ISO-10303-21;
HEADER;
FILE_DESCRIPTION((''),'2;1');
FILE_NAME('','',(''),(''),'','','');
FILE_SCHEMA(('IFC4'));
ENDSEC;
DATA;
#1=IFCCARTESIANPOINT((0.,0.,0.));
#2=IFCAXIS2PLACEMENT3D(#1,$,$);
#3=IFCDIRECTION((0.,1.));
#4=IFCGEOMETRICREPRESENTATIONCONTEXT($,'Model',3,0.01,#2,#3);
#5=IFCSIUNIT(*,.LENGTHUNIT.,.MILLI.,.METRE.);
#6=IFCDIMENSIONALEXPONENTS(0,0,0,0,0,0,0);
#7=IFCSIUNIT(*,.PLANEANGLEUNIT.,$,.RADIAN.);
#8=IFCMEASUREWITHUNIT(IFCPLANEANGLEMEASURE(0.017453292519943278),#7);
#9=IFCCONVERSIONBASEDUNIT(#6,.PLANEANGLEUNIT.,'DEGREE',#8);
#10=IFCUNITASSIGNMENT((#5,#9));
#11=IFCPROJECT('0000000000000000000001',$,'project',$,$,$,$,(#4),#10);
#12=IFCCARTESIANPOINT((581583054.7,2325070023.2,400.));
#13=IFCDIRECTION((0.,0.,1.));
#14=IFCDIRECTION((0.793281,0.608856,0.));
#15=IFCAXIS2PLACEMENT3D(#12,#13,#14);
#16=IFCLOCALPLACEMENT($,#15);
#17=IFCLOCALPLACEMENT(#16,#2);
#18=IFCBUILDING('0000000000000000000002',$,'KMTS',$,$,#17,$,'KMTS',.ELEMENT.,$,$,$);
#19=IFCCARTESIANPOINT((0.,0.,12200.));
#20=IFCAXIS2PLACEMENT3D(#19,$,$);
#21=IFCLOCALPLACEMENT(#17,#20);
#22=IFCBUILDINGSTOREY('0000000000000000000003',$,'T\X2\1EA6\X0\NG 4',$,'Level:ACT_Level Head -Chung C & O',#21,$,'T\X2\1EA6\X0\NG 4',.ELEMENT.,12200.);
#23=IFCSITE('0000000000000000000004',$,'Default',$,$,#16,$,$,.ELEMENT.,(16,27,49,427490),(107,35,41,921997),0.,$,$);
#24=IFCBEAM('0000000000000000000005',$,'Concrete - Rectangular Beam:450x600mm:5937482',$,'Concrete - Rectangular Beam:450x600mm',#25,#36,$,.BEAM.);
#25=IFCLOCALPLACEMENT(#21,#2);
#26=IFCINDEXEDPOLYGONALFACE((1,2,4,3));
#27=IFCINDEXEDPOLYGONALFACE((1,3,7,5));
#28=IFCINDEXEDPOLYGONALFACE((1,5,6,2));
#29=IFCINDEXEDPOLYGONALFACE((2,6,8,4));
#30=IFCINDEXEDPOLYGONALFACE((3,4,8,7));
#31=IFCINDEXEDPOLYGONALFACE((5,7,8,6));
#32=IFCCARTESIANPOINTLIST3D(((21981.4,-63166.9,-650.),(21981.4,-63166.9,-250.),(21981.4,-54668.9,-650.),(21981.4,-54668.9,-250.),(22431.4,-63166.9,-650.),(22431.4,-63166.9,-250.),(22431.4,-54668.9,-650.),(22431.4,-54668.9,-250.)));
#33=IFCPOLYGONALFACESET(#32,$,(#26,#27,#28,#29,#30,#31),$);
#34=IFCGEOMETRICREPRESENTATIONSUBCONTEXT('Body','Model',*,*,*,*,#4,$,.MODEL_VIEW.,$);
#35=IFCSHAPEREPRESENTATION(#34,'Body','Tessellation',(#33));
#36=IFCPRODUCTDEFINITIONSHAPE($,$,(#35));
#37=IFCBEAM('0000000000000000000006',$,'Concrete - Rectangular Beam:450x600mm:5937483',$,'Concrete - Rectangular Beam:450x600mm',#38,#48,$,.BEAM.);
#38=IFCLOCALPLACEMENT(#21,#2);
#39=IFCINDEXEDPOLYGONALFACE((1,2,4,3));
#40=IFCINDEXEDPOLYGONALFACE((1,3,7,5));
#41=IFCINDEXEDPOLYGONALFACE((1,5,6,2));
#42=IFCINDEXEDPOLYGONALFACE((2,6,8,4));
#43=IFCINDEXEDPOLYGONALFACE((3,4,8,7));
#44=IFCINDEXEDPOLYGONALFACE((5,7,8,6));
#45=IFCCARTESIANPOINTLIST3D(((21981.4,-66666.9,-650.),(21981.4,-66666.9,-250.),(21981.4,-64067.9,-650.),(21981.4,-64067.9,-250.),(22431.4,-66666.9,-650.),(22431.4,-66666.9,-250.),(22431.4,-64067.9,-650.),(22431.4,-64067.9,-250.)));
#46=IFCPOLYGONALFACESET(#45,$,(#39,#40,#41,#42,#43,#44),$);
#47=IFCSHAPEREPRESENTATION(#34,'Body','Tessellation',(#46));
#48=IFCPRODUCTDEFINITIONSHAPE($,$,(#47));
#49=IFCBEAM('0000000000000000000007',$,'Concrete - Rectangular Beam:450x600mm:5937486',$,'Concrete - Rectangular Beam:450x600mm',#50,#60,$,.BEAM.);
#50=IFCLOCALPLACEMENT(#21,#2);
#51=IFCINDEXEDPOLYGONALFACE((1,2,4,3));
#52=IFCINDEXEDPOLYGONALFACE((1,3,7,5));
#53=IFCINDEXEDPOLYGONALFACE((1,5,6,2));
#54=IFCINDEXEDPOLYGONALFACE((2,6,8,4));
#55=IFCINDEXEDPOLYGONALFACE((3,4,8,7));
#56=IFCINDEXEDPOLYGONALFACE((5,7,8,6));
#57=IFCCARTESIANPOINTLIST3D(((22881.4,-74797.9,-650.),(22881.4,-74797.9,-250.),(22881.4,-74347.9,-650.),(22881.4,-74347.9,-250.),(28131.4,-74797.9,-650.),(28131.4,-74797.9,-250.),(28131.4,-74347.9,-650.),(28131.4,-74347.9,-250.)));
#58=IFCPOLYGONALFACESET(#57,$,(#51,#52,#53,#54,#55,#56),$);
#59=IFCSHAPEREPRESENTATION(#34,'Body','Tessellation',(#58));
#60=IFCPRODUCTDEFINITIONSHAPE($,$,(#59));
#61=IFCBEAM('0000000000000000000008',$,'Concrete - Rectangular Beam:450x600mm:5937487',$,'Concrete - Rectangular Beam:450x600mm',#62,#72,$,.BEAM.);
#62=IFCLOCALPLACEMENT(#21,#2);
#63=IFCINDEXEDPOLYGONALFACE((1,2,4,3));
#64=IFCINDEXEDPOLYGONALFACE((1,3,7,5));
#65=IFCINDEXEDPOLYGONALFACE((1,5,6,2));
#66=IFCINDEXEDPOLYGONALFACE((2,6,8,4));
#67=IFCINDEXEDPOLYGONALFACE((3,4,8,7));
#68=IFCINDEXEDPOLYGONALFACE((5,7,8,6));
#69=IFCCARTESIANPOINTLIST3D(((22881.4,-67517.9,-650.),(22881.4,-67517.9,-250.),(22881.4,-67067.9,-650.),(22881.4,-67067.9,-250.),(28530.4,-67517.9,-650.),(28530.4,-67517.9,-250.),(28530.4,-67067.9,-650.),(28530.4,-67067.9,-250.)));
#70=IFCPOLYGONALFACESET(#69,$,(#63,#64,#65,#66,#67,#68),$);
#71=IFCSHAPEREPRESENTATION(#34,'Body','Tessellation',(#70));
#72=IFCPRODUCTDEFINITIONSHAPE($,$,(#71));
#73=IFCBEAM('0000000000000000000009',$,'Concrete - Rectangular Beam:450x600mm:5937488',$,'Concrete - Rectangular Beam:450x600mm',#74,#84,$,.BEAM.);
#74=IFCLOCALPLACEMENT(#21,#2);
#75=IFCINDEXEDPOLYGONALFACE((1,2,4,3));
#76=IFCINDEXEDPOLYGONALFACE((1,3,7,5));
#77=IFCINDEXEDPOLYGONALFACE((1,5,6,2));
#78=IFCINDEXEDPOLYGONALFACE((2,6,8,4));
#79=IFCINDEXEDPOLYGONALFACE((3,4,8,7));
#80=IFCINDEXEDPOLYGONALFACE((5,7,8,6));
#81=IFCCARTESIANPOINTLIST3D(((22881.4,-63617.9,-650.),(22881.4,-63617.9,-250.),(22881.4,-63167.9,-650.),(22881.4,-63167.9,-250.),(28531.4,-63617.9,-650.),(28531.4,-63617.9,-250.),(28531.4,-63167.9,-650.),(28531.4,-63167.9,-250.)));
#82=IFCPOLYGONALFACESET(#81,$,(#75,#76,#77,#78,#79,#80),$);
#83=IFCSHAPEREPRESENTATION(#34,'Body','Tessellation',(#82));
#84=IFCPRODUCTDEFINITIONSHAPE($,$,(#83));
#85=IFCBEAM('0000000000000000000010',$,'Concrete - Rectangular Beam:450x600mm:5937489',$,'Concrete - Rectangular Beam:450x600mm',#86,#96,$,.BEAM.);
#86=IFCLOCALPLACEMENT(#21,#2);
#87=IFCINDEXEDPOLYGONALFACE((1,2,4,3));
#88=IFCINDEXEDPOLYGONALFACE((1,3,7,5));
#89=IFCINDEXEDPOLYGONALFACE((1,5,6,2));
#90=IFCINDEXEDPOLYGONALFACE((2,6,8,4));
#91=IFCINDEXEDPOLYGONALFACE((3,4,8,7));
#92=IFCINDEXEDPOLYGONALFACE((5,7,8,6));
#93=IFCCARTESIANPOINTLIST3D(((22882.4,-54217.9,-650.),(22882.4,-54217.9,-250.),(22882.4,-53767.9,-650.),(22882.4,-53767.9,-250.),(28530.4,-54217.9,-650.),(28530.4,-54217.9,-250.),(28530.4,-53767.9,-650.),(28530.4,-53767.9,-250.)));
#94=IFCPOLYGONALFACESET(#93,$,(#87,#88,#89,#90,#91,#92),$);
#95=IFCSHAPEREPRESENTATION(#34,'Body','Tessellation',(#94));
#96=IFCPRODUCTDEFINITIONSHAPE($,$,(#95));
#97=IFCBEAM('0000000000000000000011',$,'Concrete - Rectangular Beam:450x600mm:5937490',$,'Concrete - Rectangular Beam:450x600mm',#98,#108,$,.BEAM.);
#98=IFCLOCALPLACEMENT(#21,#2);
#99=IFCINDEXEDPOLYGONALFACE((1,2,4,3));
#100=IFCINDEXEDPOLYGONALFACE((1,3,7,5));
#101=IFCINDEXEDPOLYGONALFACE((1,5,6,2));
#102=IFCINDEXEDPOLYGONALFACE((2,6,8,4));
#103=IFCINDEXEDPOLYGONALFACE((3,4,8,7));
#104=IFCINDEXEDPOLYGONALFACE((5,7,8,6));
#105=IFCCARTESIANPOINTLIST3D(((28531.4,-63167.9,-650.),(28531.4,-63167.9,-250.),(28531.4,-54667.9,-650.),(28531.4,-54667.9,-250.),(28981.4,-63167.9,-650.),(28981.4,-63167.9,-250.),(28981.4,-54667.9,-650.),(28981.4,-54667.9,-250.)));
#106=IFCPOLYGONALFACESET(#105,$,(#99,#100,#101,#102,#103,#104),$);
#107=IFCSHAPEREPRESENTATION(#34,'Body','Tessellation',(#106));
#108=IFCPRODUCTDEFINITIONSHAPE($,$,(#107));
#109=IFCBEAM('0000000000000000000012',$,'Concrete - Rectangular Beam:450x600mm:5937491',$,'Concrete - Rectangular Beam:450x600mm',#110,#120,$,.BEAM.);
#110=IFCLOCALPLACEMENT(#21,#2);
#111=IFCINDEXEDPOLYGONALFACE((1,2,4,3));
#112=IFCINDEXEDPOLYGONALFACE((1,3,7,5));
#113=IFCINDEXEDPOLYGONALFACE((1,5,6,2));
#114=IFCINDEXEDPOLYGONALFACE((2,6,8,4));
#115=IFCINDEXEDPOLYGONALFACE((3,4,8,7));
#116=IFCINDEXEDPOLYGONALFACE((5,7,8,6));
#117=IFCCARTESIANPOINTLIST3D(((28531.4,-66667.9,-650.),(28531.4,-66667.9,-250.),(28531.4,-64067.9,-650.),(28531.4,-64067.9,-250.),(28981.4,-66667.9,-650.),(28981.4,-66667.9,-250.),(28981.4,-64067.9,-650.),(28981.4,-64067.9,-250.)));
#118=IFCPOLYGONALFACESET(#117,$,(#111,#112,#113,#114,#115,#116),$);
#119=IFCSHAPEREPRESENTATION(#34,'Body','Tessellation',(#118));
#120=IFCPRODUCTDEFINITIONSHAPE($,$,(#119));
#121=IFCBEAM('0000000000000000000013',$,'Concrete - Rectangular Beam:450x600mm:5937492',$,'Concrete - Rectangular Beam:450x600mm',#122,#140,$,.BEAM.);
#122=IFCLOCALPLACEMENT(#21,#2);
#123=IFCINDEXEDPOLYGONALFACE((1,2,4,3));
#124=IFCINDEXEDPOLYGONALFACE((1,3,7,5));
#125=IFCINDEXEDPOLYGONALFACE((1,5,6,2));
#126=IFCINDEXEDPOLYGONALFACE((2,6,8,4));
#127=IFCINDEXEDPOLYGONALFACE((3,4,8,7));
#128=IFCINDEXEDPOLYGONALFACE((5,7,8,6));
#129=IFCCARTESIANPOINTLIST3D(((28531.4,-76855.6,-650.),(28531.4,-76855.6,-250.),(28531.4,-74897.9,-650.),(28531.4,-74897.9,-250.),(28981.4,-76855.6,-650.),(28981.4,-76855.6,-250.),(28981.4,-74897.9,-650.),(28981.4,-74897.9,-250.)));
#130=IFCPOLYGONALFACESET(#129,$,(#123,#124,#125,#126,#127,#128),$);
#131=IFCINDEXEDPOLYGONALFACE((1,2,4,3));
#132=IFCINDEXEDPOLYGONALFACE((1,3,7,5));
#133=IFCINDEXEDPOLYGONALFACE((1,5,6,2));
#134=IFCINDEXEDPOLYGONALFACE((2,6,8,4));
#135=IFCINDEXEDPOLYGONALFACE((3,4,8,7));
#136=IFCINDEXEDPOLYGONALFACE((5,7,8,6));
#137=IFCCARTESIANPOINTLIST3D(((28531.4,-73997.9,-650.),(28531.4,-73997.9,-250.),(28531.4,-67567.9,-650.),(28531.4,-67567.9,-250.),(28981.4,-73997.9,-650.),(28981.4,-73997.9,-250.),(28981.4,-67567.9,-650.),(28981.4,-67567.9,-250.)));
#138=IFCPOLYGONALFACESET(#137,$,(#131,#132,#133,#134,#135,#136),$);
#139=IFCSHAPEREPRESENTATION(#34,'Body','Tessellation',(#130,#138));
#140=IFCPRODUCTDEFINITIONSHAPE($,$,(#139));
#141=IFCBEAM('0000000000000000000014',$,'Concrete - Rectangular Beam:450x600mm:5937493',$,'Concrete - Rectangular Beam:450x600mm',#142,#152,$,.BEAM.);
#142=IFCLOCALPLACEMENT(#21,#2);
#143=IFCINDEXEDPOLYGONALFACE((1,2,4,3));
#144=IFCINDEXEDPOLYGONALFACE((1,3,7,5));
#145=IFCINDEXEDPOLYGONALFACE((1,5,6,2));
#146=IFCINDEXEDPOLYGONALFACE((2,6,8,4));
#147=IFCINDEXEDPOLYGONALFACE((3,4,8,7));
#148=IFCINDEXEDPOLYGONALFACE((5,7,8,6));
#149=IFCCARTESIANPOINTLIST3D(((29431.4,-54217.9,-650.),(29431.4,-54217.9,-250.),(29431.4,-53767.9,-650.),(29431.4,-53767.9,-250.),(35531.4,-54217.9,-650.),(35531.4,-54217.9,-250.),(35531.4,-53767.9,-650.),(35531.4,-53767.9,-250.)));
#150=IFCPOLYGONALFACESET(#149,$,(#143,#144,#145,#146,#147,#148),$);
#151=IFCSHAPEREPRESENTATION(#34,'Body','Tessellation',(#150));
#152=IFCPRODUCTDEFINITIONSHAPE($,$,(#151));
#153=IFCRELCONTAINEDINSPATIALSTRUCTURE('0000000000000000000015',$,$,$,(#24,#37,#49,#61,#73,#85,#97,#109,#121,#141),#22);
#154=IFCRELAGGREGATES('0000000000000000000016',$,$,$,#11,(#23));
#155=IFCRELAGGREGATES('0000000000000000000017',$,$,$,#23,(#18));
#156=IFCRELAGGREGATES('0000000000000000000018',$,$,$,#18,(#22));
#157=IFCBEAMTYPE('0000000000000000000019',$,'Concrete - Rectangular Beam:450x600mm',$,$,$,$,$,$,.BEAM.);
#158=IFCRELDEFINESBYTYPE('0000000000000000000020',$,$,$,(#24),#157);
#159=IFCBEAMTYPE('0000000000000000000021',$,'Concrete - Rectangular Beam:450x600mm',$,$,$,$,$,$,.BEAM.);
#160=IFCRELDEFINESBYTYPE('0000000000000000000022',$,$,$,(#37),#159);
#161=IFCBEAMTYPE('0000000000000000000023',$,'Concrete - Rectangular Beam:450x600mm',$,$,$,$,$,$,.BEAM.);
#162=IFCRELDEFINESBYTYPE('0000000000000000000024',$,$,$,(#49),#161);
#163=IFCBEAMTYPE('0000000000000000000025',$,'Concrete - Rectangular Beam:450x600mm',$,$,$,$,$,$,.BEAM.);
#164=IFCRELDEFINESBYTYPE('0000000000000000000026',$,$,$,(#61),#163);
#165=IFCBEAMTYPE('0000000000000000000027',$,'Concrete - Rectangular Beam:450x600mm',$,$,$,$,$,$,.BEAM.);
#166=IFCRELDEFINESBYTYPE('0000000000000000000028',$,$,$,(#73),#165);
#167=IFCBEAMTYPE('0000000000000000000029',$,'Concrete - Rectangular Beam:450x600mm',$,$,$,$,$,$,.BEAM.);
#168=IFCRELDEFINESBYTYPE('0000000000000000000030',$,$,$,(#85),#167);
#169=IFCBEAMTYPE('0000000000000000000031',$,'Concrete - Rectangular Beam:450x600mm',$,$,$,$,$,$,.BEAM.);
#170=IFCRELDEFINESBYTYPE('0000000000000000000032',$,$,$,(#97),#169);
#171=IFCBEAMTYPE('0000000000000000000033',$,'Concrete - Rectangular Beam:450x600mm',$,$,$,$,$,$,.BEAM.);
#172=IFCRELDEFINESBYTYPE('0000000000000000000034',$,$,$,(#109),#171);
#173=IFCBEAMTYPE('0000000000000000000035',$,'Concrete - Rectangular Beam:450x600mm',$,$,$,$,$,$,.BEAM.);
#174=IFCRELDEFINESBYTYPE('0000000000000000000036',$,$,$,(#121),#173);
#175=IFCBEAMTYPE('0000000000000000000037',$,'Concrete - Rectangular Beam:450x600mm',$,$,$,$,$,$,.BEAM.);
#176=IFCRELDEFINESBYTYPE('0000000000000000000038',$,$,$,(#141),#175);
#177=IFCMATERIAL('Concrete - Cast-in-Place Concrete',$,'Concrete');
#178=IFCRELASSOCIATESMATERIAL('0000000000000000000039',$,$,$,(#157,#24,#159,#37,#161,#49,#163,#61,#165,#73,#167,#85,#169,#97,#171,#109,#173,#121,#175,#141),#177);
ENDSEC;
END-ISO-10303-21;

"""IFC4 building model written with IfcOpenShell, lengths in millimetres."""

from ifc_helpers import new_model, entity, si_unit, converted_unit, direction, frame, origin, place, context, subcontext, project, spatial, indexed_curve, outline, extrude, source, transform, mapped, material, type_object, type_shapes, element, save


model = new_model("IFC4")

# Units and contexts
model_context = context("Model", 3, precision=0.01, world=origin(), true_north=direction((0.0, 1.0)))
body_context = subcontext(model_context, "Body", "Model", "MODEL_VIEW")
ifc_project = project(units=[si_unit("LENGTHUNIT", "METRE", prefix="MILLI"), converted_unit("PLANEANGLEUNIT", "DEGREE", entity("IfcPlaneAngleMeasure", 0.017453292519943278), si_unit("PLANEANGLEUNIT", "RADIAN"), dimensions=[0, 0, 0, 0, 0, 0, 0])], contexts=[model_context])

# Site, building, storey
site_placement = place(None, frame((581583054.7, 2325070023.2, 400.0), z_axis=(0.0, 0.0, 1.0), x_axis=(0.793281, 0.608856, 0.0)))
site = spatial("IfcSite", under=ifc_project, at=site_placement, Name="Default", CompositionType="ELEMENT", RefLatitude=(16, 27, 49, 427490), RefLongitude=(107, 35, 41, 921997), RefElevation=0.0)
building_placement = place(site_placement, origin())
building = spatial("IfcBuilding", under=site, at=building_placement, Name="KMTS", LongName="KMTS", CompositionType="ELEMENT")
storey_placement = place(building_placement, frame((0.0, 0.0, 12200.0)))
storey = spatial("IfcBuildingStorey", under=building, at=storey_placement, Name="TẦNG 4", ObjectType="Level:ACT_Level Head -Chung C & O", LongName="TẦNG 4", CompositionType="ELEMENT", Elevation=12200.0)

# Beams
ifc_material = material(Name="Concrete - Cast-in-Place Concrete", Category="Concrete")
beam_type_1 = type_object("IfcBeamType", Name="Concrete - Rectangular Beam:450x600mm", PredefinedType="BEAM", material=ifc_material)
shared_shape_1 = source(origin(), body_context, "Body", "SweptSolid", [
    extrude(outline(indexed_curve([(-225.0, -200.0), (225.0, -200.0), (225.0, 200.0), (-225.0, 200.0), (-225.0, -200.0)], self_intersect=False)), frame((22206.4, -54668.9, 11750.0), z_axis=(0.0, -1.0, 0.0), x_axis=(-1.0, 0.0, 0.0)), (0.0, 0.0, 1.0), 8498.0),
])
type_shapes(beam_type_1, [shared_shape_1])
beam_1_placement = place(storey_placement, frame((0.0, 0.0, -12200.0)))
element("IfcBeam", 1, at=beam_1_placement, inside=storey, type_object=beam_type_1, material=ifc_material, Name="Concrete - Rectangular Beam:450x600mm:5937482", ObjectType="Concrete - Rectangular Beam:450x600mm", PredefinedType="BEAM", context=body_context, shape_type="MappedRepresentation", body=[
    mapped(shared_shape_1, transform((0.0, 0.0, 0.0), scale=1.0)),
])
beam_type_2 = type_object("IfcBeamType", Name="Concrete - Rectangular Beam:450x600mm", PredefinedType="BEAM", material=ifc_material)
shared_shape_2 = source(origin(), body_context, "Body", "SweptSolid", [
    extrude(outline(indexed_curve([(-225.0, -200.0), (225.0, -200.0), (225.0, 200.0), (-225.0, 200.0), (-225.0, -200.0)], self_intersect=False)), frame((22206.4, -66666.9, 11750.0), z_axis=(0.0, 1.0, 0.0), x_axis=(-1.0, 0.0, 0.0)), (0.0, 0.0, 1.0), 2599.0),
])
type_shapes(beam_type_2, [shared_shape_2])
beam_2_placement = place(storey_placement, frame((0.0, 0.0, -12200.0)))
element("IfcBeam", 2, at=beam_2_placement, inside=storey, type_object=beam_type_2, material=ifc_material, Name="Concrete - Rectangular Beam:450x600mm:5937483", ObjectType="Concrete - Rectangular Beam:450x600mm", PredefinedType="BEAM", context=body_context, shape_type="MappedRepresentation", body=[
    mapped(shared_shape_2, transform((0.0, 0.0, 0.0), scale=1.0)),
])
beam_type_3 = type_object("IfcBeamType", Name="Concrete - Rectangular Beam:450x600mm", PredefinedType="BEAM", material=ifc_material)
shared_shape_3 = source(origin(), body_context, "Body", "SweptSolid", [
    extrude(outline(indexed_curve([(-200.0, -225.0), (200.0, -225.0), (200.0, 225.0), (-200.0, 225.0), (-200.0, -225.0)], self_intersect=False)), frame((22881.4, -74572.9, 11750.0), z_axis=(1.0, 0.0, 0.0), x_axis=(0.0, 0.0, -1.0)), (0.0, 0.0, 1.0), 5250.0),
])
type_shapes(beam_type_3, [shared_shape_3])
beam_3_placement = place(storey_placement, frame((0.0, 0.0, -12200.0)))
element("IfcBeam", 3, at=beam_3_placement, inside=storey, type_object=beam_type_3, material=ifc_material, Name="Concrete - Rectangular Beam:450x600mm:5937486", ObjectType="Concrete - Rectangular Beam:450x600mm", PredefinedType="BEAM", context=body_context, shape_type="MappedRepresentation", body=[
    mapped(shared_shape_3, transform((0.0, 0.0, 0.0), scale=1.0)),
])
beam_type_4 = type_object("IfcBeamType", Name="Concrete - Rectangular Beam:450x600mm", PredefinedType="BEAM", material=ifc_material)
shared_shape_4 = source(origin(), body_context, "Body", "SweptSolid", [
    extrude(outline(indexed_curve([(-200.0, -225.0), (200.0, -225.0), (200.0, 225.0), (-200.0, 225.0), (-200.0, -225.0)], self_intersect=False)), frame((22881.4, -67292.9, 11750.0), z_axis=(1.0, 0.0, 0.0), x_axis=(0.0, 0.0, -1.0)), (0.0, 0.0, 1.0), 5649.0),
])
type_shapes(beam_type_4, [shared_shape_4])
beam_4_placement = place(storey_placement, frame((0.0, 0.0, -12200.0)))
element("IfcBeam", 4, at=beam_4_placement, inside=storey, type_object=beam_type_4, material=ifc_material, Name="Concrete - Rectangular Beam:450x600mm:5937487", ObjectType="Concrete - Rectangular Beam:450x600mm", PredefinedType="BEAM", context=body_context, shape_type="MappedRepresentation", body=[
    mapped(shared_shape_4, transform((0.0, 0.0, 0.0), scale=1.0)),
])
beam_type_5 = type_object("IfcBeamType", Name="Concrete - Rectangular Beam:450x600mm", PredefinedType="BEAM", material=ifc_material)
shared_shape_5 = source(origin(), body_context, "Body", "SweptSolid", [
    extrude(outline(indexed_curve([(-200.0, -225.0), (200.0, -225.0), (200.0, 225.0), (-200.0, 225.0), (-200.0, -225.0)], self_intersect=False)), frame((22881.4, -63392.9, 11750.0), z_axis=(1.0, 0.0, 0.0), x_axis=(0.0, 0.0, -1.0)), (0.0, 0.0, 1.0), 5650.0),
])
type_shapes(beam_type_5, [shared_shape_5])
beam_5_placement = place(storey_placement, frame((0.0, 0.0, -12200.0)))
element("IfcBeam", 5, at=beam_5_placement, inside=storey, type_object=beam_type_5, material=ifc_material, Name="Concrete - Rectangular Beam:450x600mm:5937488", ObjectType="Concrete - Rectangular Beam:450x600mm", PredefinedType="BEAM", context=body_context, shape_type="MappedRepresentation", body=[
    mapped(shared_shape_5, transform((0.0, 0.0, 0.0), scale=1.0)),
])
beam_type_6 = type_object("IfcBeamType", Name="Concrete - Rectangular Beam:450x600mm", PredefinedType="BEAM", material=ifc_material)
shared_shape_6 = source(origin(), body_context, "Body", "SweptSolid", [
    extrude(outline(indexed_curve([(-200.0, -225.0), (200.0, -225.0), (200.0, 225.0), (-200.0, 225.0), (-200.0, -225.0)], self_intersect=False)), frame((28530.4, -53992.9, 11750.0), z_axis=(-1.0, 0.0, 0.0), x_axis=(0.0, 0.0, -1.0)), (0.0, 0.0, 1.0), 5648.0),
])
type_shapes(beam_type_6, [shared_shape_6])
beam_6_placement = place(storey_placement, frame((0.0, 0.0, -12200.0)))
element("IfcBeam", 6, at=beam_6_placement, inside=storey, type_object=beam_type_6, material=ifc_material, Name="Concrete - Rectangular Beam:450x600mm:5937489", ObjectType="Concrete - Rectangular Beam:450x600mm", PredefinedType="BEAM", context=body_context, shape_type="MappedRepresentation", body=[
    mapped(shared_shape_6, transform((0.0, 0.0, 0.0), scale=1.0)),
])
beam_type_7 = type_object("IfcBeamType", Name="Concrete - Rectangular Beam:450x600mm", PredefinedType="BEAM", material=ifc_material)
shared_shape_7 = source(origin(), body_context, "Body", "SweptSolid", [
    extrude(outline(indexed_curve([(-225.0, -200.0), (225.0, -200.0), (225.0, 200.0), (-225.0, 200.0), (-225.0, -200.0)], self_intersect=False)), frame((28756.4, -63167.9, 11750.0), z_axis=(0.0, 1.0, 0.0), x_axis=(-1.0, 0.0, 0.0)), (0.0, 0.0, 1.0), 8500.0),
])
type_shapes(beam_type_7, [shared_shape_7])
beam_7_placement = place(storey_placement, frame((0.0, 0.0, -12200.0)))
element("IfcBeam", 7, at=beam_7_placement, inside=storey, type_object=beam_type_7, material=ifc_material, Name="Concrete - Rectangular Beam:450x600mm:5937490", ObjectType="Concrete - Rectangular Beam:450x600mm", PredefinedType="BEAM", context=body_context, shape_type="MappedRepresentation", body=[
    mapped(shared_shape_7, transform((0.0, 0.0, 0.0), scale=1.0)),
])
beam_type_8 = type_object("IfcBeamType", Name="Concrete - Rectangular Beam:450x600mm", PredefinedType="BEAM", material=ifc_material)
shared_shape_8 = source(origin(), body_context, "Body", "SweptSolid", [
    extrude(outline(indexed_curve([(-225.0, -200.0), (225.0, -200.0), (225.0, 200.0), (-225.0, 200.0), (-225.0, -200.0)], self_intersect=False)), frame((28756.4, -66667.9, 11750.0), z_axis=(0.0, 1.0, 0.0), x_axis=(-1.0, 0.0, 0.0)), (0.0, 0.0, 1.0), 2600.0),
])
type_shapes(beam_type_8, [shared_shape_8])
beam_8_placement = place(storey_placement, frame((0.0, 0.0, -12200.0)))
element("IfcBeam", 8, at=beam_8_placement, inside=storey, type_object=beam_type_8, material=ifc_material, Name="Concrete - Rectangular Beam:450x600mm:5937491", ObjectType="Concrete - Rectangular Beam:450x600mm", PredefinedType="BEAM", context=body_context, shape_type="MappedRepresentation", body=[
    mapped(shared_shape_8, transform((0.0, 0.0, 0.0), scale=1.0)),
])
beam_type_9 = type_object("IfcBeamType", Name="Concrete - Rectangular Beam:450x600mm", PredefinedType="BEAM", material=ifc_material)
shared_shape_9 = source(origin(), body_context, "Body", "SweptSolid", [
    extrude(outline(indexed_curve([(-225.0, -200.0), (225.0, -200.0), (225.0, 200.0), (-225.0, 200.0), (-225.0, -200.0)], self_intersect=False)), frame((28756.4, -76855.6, 11750.0), z_axis=(0.0, 1.0, 0.0), x_axis=(-1.0, 0.0, 0.0)), (0.0, 0.0, 1.0), 1957.7),
    extrude(outline(indexed_curve([(-225.0, -200.0), (225.0, -200.0), (225.0, 200.0), (-225.0, 200.0), (-225.0, -200.0)], self_intersect=False)), frame((28756.4, -73997.9, 11750.0), z_axis=(0.0, 1.0, 0.0), x_axis=(-1.0, 0.0, 0.0)), (0.0, 0.0, 1.0), 6430.0),
])
type_shapes(beam_type_9, [shared_shape_9])
beam_9_placement = place(storey_placement, frame((0.0, 0.0, -12200.0)))
element("IfcBeam", 9, at=beam_9_placement, inside=storey, type_object=beam_type_9, material=ifc_material, Name="Concrete - Rectangular Beam:450x600mm:5937492", ObjectType="Concrete - Rectangular Beam:450x600mm", PredefinedType="BEAM", context=body_context, shape_type="MappedRepresentation", body=[
    mapped(shared_shape_9, transform((0.0, 0.0, 0.0), scale=1.0)),
])
beam_type_10 = type_object("IfcBeamType", Name="Concrete - Rectangular Beam:450x600mm", PredefinedType="BEAM", material=ifc_material)
shared_shape_10 = source(origin(), body_context, "Body", "SweptSolid", [
    extrude(outline(indexed_curve([(-200.0, -225.0), (200.0, -225.0), (200.0, 225.0), (-200.0, 225.0), (-200.0, -225.0)], self_intersect=False)), frame((29431.4, -53992.9, 11750.0), z_axis=(1.0, 0.0, 0.0), x_axis=(0.0, 0.0, -1.0)), (0.0, 0.0, 1.0), 6100.0),
])
type_shapes(beam_type_10, [shared_shape_10])
beam_10_placement = place(storey_placement, frame((0.0, 0.0, -12200.0)))
element("IfcBeam", 10, at=beam_10_placement, inside=storey, type_object=beam_type_10, material=ifc_material, Name="Concrete - Rectangular Beam:450x600mm:5937493", ObjectType="Concrete - Rectangular Beam:450x600mm", PredefinedType="BEAM", context=body_context, shape_type="MappedRepresentation", body=[
    mapped(shared_shape_10, transform((0.0, 0.0, 0.0), scale=1.0)),
])

save(model, "model.ifc")
